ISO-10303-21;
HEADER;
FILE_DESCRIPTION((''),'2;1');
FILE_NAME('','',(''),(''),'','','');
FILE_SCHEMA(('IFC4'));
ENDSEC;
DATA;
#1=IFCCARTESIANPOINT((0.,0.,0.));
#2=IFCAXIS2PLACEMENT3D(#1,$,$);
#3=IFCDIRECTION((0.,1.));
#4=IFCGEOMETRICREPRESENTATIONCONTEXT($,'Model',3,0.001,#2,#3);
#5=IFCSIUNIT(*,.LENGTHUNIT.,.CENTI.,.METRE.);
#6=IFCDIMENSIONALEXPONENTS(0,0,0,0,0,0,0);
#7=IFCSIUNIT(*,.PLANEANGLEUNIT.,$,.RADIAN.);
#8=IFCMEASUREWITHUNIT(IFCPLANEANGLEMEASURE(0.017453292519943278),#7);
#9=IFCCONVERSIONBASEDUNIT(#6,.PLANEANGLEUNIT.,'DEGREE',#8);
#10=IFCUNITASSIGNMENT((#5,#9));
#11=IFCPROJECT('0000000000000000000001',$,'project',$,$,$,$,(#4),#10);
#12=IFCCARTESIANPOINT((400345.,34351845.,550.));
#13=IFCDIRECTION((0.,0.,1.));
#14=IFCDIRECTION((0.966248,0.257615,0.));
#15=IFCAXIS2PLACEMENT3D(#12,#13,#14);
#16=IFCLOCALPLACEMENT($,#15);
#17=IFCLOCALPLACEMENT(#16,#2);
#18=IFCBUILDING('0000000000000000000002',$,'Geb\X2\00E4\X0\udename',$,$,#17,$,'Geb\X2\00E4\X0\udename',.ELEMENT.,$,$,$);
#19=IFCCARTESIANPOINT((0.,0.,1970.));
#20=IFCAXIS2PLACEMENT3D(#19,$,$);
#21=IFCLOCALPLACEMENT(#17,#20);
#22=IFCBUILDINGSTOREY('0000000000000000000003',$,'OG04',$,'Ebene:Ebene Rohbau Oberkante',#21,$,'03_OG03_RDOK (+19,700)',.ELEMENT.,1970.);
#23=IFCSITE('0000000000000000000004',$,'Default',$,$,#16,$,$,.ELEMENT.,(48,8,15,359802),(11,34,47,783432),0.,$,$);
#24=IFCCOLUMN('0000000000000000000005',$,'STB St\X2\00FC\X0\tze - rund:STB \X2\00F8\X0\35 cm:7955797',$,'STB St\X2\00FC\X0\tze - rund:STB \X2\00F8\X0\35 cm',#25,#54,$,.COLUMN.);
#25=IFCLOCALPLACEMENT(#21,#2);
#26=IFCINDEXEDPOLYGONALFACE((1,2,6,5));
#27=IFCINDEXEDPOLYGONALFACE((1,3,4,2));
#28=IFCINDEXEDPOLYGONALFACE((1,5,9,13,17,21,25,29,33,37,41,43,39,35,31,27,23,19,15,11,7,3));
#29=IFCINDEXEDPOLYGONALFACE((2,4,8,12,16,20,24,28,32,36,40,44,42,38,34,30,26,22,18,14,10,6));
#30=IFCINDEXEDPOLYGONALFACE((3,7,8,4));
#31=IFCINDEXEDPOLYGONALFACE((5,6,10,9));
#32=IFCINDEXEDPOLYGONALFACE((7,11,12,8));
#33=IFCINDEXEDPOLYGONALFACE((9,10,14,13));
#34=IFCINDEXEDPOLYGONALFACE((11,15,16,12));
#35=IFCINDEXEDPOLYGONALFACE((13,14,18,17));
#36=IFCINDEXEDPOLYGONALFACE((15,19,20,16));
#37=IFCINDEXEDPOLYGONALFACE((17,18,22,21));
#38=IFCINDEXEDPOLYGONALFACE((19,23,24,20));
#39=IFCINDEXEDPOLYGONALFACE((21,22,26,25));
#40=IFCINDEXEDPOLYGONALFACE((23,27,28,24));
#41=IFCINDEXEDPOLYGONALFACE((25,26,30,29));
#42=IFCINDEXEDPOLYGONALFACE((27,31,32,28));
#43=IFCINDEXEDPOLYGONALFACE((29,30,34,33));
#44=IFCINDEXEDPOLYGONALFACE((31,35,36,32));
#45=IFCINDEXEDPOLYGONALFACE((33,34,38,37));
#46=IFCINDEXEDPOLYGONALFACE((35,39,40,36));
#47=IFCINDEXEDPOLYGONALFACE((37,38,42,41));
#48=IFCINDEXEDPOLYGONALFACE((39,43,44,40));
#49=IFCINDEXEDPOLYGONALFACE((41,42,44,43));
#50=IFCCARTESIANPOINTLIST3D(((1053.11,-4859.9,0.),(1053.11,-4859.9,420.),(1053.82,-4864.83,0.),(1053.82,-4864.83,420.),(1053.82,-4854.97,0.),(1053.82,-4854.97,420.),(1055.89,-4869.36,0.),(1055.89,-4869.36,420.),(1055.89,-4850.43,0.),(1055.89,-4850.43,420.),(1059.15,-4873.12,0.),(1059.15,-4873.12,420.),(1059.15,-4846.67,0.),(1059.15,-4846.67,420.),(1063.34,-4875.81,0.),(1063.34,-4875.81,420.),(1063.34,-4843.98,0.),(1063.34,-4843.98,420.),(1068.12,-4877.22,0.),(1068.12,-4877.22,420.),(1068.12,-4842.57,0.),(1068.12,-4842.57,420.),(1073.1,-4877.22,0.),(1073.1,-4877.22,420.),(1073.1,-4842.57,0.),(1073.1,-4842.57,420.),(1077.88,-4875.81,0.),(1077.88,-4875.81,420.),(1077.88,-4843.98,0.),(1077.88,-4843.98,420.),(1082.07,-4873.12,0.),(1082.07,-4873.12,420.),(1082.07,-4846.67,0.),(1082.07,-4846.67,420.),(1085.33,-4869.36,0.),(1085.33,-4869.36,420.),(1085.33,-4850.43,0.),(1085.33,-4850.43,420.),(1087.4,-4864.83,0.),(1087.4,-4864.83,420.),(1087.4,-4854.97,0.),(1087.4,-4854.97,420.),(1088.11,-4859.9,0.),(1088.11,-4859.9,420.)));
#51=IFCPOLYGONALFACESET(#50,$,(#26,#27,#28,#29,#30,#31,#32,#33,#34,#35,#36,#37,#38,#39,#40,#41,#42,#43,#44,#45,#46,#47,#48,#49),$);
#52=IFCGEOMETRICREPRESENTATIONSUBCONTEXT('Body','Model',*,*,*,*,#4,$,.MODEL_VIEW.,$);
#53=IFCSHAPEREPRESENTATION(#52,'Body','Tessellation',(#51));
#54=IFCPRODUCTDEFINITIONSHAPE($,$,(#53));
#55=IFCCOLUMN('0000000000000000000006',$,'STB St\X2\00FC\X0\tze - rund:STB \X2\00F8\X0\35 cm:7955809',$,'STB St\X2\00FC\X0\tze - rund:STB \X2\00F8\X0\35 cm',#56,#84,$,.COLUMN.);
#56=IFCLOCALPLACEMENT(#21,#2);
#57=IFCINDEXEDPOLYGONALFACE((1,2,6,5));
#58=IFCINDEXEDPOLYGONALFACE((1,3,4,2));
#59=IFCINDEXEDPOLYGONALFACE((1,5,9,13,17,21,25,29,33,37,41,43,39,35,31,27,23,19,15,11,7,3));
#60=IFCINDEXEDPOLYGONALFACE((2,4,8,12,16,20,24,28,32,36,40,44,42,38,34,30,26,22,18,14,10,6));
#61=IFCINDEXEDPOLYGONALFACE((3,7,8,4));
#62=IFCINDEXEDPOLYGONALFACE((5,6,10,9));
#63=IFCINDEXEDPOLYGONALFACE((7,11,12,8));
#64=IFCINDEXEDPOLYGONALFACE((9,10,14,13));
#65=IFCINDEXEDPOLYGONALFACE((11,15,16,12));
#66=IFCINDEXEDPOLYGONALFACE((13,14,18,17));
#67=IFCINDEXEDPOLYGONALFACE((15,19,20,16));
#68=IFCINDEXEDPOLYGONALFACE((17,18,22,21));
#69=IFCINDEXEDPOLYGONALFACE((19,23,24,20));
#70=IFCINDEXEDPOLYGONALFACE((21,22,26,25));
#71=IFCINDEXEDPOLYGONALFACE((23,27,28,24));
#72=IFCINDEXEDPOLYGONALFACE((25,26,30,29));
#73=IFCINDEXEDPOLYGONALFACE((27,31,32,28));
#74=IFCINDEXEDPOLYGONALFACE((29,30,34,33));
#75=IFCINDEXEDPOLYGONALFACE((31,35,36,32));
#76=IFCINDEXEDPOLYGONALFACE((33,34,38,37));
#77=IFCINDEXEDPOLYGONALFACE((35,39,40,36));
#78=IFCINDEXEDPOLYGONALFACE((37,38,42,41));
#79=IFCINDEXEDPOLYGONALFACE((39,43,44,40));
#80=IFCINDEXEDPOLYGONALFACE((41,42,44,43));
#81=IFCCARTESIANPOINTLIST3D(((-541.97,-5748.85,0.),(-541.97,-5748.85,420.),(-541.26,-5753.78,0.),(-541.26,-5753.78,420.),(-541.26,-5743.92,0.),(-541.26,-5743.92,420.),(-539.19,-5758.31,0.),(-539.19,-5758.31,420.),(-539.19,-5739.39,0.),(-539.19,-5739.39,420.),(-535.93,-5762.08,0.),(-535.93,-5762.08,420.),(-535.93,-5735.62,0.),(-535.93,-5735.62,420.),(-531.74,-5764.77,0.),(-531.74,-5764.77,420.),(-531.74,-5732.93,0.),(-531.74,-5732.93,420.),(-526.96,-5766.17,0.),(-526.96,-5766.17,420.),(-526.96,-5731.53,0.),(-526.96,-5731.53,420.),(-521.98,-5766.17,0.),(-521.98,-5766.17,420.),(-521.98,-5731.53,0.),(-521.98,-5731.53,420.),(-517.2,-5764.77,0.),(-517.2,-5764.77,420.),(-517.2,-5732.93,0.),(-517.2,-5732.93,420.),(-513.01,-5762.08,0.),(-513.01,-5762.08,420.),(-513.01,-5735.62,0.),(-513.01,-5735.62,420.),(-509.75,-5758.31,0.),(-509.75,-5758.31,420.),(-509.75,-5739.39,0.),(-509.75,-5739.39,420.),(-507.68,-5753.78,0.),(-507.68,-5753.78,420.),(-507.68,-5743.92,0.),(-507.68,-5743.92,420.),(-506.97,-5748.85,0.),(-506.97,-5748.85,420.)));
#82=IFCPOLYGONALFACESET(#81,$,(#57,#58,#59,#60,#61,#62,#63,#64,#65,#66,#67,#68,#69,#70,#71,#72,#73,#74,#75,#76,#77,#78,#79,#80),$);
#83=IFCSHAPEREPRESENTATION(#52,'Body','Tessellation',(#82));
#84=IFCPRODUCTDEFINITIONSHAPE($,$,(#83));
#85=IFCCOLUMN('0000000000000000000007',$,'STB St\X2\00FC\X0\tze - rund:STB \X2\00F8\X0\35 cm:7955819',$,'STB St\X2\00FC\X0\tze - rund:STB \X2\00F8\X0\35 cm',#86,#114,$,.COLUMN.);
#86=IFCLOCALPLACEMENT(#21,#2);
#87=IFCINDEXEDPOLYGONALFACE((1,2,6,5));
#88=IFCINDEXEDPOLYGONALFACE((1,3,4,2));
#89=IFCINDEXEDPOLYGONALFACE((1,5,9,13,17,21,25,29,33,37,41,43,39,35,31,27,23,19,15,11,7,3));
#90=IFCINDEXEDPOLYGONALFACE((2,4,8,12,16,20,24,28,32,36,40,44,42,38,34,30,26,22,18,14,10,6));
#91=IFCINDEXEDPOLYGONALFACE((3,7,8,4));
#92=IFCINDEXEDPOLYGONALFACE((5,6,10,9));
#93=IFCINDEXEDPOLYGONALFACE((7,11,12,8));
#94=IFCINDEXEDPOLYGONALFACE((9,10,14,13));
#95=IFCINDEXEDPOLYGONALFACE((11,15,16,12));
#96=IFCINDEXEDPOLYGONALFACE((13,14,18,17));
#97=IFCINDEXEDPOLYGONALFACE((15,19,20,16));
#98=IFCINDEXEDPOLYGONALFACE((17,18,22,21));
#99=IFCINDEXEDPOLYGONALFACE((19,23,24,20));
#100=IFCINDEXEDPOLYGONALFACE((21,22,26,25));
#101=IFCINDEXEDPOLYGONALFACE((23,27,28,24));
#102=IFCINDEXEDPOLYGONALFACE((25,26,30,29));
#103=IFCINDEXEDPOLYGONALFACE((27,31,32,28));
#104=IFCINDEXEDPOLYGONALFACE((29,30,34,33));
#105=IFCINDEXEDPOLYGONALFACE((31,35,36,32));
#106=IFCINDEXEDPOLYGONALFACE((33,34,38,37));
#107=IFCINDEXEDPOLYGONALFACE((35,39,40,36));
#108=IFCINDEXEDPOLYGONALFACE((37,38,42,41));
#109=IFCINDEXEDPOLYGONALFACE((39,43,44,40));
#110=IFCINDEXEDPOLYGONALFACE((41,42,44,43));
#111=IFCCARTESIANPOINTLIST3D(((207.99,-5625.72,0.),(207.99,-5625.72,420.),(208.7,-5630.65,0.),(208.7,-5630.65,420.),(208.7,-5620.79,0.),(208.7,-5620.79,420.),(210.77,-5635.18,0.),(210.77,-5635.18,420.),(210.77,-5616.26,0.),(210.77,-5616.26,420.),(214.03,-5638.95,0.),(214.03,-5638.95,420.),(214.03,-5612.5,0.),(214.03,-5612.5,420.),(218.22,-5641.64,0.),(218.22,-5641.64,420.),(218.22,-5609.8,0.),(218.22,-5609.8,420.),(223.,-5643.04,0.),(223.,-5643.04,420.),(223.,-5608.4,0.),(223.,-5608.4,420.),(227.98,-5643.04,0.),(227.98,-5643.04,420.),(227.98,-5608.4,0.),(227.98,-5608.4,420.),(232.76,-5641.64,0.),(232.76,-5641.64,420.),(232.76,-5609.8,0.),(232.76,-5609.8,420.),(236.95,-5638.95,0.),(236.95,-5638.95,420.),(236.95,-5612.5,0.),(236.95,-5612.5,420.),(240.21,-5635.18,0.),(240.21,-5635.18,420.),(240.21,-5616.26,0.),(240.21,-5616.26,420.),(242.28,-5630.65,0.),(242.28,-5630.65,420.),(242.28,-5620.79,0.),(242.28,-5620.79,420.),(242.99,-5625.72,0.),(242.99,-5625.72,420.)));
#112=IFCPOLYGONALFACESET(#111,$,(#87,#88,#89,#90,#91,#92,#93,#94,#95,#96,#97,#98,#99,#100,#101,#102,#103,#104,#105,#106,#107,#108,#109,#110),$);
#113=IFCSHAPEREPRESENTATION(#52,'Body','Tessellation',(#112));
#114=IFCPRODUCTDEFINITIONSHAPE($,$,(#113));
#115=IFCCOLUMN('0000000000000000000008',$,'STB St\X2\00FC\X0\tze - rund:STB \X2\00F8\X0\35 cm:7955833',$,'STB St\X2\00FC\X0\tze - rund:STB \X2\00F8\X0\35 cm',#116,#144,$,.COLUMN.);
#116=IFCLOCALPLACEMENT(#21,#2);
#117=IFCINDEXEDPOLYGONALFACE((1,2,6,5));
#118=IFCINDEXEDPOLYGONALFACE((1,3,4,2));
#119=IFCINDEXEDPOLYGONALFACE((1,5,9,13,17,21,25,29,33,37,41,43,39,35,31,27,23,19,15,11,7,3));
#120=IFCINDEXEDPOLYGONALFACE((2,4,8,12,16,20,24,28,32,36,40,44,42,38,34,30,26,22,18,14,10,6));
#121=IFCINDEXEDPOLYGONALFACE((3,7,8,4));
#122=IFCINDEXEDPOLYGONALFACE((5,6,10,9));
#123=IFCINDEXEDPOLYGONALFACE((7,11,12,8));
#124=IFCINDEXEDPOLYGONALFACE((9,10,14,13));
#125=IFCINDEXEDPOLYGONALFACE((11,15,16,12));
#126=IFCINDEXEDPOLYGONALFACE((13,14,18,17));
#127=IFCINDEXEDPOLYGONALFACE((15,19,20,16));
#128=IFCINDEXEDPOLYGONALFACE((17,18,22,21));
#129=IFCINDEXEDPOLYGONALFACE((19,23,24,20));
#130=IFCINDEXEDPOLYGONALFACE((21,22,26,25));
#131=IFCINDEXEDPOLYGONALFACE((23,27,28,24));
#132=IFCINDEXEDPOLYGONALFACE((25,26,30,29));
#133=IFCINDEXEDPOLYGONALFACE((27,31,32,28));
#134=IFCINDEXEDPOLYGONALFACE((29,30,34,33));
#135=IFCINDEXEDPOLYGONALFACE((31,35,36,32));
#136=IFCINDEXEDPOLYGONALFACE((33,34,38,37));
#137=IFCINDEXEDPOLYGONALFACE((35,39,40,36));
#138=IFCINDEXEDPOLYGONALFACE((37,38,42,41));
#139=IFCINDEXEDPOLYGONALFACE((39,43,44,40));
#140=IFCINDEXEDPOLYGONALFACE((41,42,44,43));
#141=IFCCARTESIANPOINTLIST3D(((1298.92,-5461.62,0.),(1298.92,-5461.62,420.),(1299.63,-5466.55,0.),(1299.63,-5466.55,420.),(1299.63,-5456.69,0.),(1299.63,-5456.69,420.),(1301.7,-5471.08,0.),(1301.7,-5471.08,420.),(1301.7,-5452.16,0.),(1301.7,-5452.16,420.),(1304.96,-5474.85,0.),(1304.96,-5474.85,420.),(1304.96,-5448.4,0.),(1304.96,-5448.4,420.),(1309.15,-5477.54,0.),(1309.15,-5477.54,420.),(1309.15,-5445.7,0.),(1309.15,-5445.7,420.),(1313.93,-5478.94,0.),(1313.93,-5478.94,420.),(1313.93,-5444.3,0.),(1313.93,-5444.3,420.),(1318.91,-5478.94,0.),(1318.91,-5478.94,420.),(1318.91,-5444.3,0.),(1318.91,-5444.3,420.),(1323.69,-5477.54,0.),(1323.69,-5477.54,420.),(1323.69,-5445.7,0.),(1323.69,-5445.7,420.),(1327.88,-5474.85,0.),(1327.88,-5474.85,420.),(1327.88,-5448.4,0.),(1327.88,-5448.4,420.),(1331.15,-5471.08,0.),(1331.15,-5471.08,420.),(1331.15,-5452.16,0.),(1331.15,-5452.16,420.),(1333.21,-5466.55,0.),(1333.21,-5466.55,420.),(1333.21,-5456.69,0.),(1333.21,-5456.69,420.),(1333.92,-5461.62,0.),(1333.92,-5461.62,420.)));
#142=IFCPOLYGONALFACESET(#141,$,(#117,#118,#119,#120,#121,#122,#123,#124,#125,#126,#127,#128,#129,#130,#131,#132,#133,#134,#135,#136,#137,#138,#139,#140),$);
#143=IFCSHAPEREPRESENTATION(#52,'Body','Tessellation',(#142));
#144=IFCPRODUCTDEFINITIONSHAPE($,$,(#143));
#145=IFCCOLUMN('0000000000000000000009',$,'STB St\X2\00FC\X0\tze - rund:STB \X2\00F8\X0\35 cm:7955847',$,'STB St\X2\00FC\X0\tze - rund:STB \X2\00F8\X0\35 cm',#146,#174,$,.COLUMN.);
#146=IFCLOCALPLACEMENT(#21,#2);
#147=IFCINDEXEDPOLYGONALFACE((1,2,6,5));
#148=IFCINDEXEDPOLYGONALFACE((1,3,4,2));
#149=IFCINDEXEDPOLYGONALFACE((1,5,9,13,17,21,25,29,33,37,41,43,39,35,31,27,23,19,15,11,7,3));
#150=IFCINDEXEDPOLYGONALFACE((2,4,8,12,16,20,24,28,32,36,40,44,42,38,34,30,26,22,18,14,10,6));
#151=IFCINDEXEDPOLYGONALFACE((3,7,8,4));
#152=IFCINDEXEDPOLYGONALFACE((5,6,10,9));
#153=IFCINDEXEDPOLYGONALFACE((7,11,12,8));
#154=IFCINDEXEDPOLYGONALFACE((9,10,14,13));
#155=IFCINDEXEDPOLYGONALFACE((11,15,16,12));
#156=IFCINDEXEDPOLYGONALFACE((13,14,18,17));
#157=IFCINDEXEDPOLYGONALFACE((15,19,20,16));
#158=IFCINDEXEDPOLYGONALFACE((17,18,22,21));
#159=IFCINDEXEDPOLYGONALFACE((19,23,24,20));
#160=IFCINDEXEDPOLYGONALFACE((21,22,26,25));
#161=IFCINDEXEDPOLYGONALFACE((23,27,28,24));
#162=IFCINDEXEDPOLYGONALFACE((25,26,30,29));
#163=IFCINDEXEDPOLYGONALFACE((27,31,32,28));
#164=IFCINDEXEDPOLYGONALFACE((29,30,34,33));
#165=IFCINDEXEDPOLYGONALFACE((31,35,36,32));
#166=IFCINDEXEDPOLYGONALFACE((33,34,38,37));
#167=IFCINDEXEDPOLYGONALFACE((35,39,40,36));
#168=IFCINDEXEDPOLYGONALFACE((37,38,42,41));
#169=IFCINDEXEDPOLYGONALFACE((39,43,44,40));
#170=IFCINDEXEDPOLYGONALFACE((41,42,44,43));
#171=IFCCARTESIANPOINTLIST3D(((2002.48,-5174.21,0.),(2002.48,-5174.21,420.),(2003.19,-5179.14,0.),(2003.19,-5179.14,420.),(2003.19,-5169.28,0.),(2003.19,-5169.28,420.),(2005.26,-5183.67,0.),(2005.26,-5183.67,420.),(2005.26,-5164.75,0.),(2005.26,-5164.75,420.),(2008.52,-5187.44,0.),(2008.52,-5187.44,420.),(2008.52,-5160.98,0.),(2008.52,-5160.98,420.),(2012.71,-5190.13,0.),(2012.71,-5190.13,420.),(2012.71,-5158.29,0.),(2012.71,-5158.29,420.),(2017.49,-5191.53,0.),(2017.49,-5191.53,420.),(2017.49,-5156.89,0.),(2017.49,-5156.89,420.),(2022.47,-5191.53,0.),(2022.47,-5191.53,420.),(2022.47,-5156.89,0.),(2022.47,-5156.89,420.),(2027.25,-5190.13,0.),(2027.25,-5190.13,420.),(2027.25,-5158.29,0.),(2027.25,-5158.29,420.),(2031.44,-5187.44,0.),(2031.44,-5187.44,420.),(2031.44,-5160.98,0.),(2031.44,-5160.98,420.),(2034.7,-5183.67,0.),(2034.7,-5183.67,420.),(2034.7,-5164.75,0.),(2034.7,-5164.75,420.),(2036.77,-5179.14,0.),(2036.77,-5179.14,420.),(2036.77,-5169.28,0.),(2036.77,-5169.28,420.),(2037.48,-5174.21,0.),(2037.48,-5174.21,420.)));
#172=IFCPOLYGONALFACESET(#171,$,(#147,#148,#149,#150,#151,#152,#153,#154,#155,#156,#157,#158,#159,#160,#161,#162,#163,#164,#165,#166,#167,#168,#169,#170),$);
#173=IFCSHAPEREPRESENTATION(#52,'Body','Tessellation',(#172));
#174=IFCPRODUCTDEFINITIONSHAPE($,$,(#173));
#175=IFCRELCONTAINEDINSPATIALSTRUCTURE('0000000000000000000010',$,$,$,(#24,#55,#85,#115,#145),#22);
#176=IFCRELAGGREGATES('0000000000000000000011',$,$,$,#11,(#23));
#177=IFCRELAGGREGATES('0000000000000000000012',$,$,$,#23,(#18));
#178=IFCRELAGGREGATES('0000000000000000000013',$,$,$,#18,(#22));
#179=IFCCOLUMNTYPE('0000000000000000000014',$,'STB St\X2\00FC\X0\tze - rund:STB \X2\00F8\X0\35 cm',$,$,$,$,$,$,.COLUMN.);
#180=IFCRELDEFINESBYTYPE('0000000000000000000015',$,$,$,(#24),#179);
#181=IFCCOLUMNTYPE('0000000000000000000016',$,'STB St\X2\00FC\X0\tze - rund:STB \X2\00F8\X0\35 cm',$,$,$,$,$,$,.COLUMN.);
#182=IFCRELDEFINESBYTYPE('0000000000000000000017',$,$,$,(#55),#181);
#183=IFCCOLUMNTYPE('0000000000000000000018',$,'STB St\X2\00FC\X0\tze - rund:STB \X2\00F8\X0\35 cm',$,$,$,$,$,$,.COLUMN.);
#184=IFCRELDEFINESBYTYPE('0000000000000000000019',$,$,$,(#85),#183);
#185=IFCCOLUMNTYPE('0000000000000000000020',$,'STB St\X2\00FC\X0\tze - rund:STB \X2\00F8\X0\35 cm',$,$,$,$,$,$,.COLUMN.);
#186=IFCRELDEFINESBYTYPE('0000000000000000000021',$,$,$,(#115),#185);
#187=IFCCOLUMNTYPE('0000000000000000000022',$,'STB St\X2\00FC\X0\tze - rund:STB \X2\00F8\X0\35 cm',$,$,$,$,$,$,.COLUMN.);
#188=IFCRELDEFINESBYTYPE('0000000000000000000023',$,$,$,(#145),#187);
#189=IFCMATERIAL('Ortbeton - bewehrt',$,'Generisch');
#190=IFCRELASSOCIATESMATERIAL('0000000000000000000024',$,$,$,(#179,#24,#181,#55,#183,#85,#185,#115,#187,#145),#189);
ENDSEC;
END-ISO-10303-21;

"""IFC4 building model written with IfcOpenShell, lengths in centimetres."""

from ifc_helpers import new_model, entity, si_unit, converted_unit, direction, frame, origin, place, context, subcontext, project, spatial, arc, indexed_curve, outline, extrude, source, transform, mapped, material, type_object, type_shapes, element, save


model = new_model("IFC4")

# Units and contexts
model_context = context("Model", 3, precision=0.001, world=origin(), true_north=direction((0.0, 1.0)))
body_context = subcontext(model_context, "Body", "Model", "MODEL_VIEW")
ifc_project = project(units=[si_unit("LENGTHUNIT", "METRE", prefix="CENTI"), converted_unit("PLANEANGLEUNIT", "DEGREE", entity("IfcPlaneAngleMeasure", 0.017453292519943278), si_unit("PLANEANGLEUNIT", "RADIAN"), dimensions=[0, 0, 0, 0, 0, 0, 0])], contexts=[model_context])

# Site, building, storey
site_placement = place(None, frame((400345.0, 34351845.0, 550.0), z_axis=(0.0, 0.0, 1.0), x_axis=(0.966248, 0.257615, 0.0)))
site = spatial("IfcSite", under=ifc_project, at=site_placement, Name="Default", CompositionType="ELEMENT", RefLatitude=(48, 8, 15, 359802), RefLongitude=(11, 34, 47, 783432), RefElevation=0.0)
building_placement = place(site_placement, origin())
building = spatial("IfcBuilding", under=site, at=building_placement, Name="Gebäudename", LongName="Gebäudename", CompositionType="ELEMENT")
storey_placement = place(building_placement, frame((0.0, 0.0, 1970.0)))
storey = spatial("IfcBuildingStorey", under=building, at=storey_placement, Name="OG04", ObjectType="Ebene:Ebene Rohbau Oberkante", LongName="03_OG03_RDOK (+19,700)", CompositionType="ELEMENT", Elevation=1970.0)

# Columns
ifc_material = material(Name="Ortbeton - bewehrt", Category="Generisch")
column_type_1 = type_object("IfcColumnType", Name="STB Stütze - rund:STB ø35 cm", PredefinedType="COLUMN", material=ifc_material)
shared_shape_1 = source(origin(), body_context, "Body", "SweptSolid", [
    extrude(outline(indexed_curve([(-17.5, 0.0), (0.0, -17.5), (17.5, 0.0), (0.0, 17.5)], segments=[arc(1, 2, 3), arc(3, 4, 1)], self_intersect=False)), frame((1070.61, -4859.9, 1970.0)), (0.0, 0.0, 1.0), 420.0),
])
type_shapes(column_type_1, [shared_shape_1])
column_1_placement = place(storey_placement, frame((0.0, 0.0, -1970.0)))
element("IfcColumn", 1, at=column_1_placement, inside=storey, type_object=column_type_1, material=ifc_material, Name="STB Stütze - rund:STB ø35 cm:7955797", ObjectType="STB Stütze - rund:STB ø35 cm", PredefinedType="COLUMN", context=body_context, shape_type="MappedRepresentation", body=[
    mapped(shared_shape_1, transform((0.0, 0.0, 0.0), scale=1.0)),
])
column_type_2 = type_object("IfcColumnType", Name="STB Stütze - rund:STB ø35 cm", PredefinedType="COLUMN", material=ifc_material)
shared_shape_2 = source(origin(), body_context, "Body", "SweptSolid", [
    extrude(outline(indexed_curve([(-17.5, 0.0), (0.0, -17.5), (17.5, 0.0), (0.0, 17.5)], segments=[arc(1, 2, 3), arc(3, 4, 1)], self_intersect=False)), frame((-524.47, -5748.85, 1970.0)), (0.0, 0.0, 1.0), 420.0),
])
type_shapes(column_type_2, [shared_shape_2])
column_2_placement = place(storey_placement, frame((0.0, 0.0, -1970.0)))
element("IfcColumn", 2, at=column_2_placement, inside=storey, type_object=column_type_2, material=ifc_material, Name="STB Stütze - rund:STB ø35 cm:7955809", ObjectType="STB Stütze - rund:STB ø35 cm", PredefinedType="COLUMN", context=body_context, shape_type="MappedRepresentation", body=[
    mapped(shared_shape_2, transform((0.0, 0.0, 0.0), scale=1.0)),
])
column_type_3 = type_object("IfcColumnType", Name="STB Stütze - rund:STB ø35 cm", PredefinedType="COLUMN", material=ifc_material)
shared_shape_3 = source(origin(), body_context, "Body", "SweptSolid", [
    extrude(outline(indexed_curve([(-17.5, 0.0), (0.0, -17.5), (17.5, 0.0), (0.0, 17.5)], segments=[arc(1, 2, 3), arc(3, 4, 1)], self_intersect=False)), frame((225.49, -5625.72, 1970.0)), (0.0, 0.0, 1.0), 420.0),
])
type_shapes(column_type_3, [shared_shape_3])
column_3_placement = place(storey_placement, frame((0.0, 0.0, -1970.0)))
element("IfcColumn", 3, at=column_3_placement, inside=storey, type_object=column_type_3, material=ifc_material, Name="STB Stütze - rund:STB ø35 cm:7955819", ObjectType="STB Stütze - rund:STB ø35 cm", PredefinedType="COLUMN", context=body_context, shape_type="MappedRepresentation", body=[
    mapped(shared_shape_3, transform((0.0, 0.0, 0.0), scale=1.0)),
])
column_type_4 = type_object("IfcColumnType", Name="STB Stütze - rund:STB ø35 cm", PredefinedType="COLUMN", material=ifc_material)
shared_shape_4 = source(origin(), body_context, "Body", "SweptSolid", [
    extrude(outline(indexed_curve([(-17.5, 0.0), (0.0, -17.5), (17.5, 0.0), (0.0, 17.5)], segments=[arc(1, 2, 3), arc(3, 4, 1)], self_intersect=False)), frame((1316.42, -5461.62, 1970.0)), (0.0, 0.0, 1.0), 420.0),
])
type_shapes(column_type_4, [shared_shape_4])
column_4_placement = place(storey_placement, frame((0.0, 0.0, -1970.0)))
element("IfcColumn", 4, at=column_4_placement, inside=storey, type_object=column_type_4, material=ifc_material, Name="STB Stütze - rund:STB ø35 cm:7955833", ObjectType="STB Stütze - rund:STB ø35 cm", PredefinedType="COLUMN", context=body_context, shape_type="MappedRepresentation", body=[
    mapped(shared_shape_4, transform((0.0, 0.0, 0.0), scale=1.0)),
])
column_type_5 = type_object("IfcColumnType", Name="STB Stütze - rund:STB ø35 cm", PredefinedType="COLUMN", material=ifc_material)
shared_shape_5 = source(origin(), body_context, "Body", "SweptSolid", [
    extrude(outline(indexed_curve([(-17.5, 0.0), (0.0, -17.5), (17.5, 0.0), (0.0, 17.5)], segments=[arc(1, 2, 3), arc(3, 4, 1)], self_intersect=False)), frame((2019.98, -5174.21, 1970.0)), (0.0, 0.0, 1.0), 420.0),
])
type_shapes(column_type_5, [shared_shape_5])
column_5_placement = place(storey_placement, frame((0.0, 0.0, -1970.0)))
element("IfcColumn", 5, at=column_5_placement, inside=storey, type_object=column_type_5, material=ifc_material, Name="STB Stütze - rund:STB ø35 cm:7955847", ObjectType="STB Stütze - rund:STB ø35 cm", PredefinedType="COLUMN", context=body_context, shape_type="MappedRepresentation", body=[
    mapped(shared_shape_5, transform((0.0, 0.0, 0.0), scale=1.0)),
])

save(model, "model.ifc")
